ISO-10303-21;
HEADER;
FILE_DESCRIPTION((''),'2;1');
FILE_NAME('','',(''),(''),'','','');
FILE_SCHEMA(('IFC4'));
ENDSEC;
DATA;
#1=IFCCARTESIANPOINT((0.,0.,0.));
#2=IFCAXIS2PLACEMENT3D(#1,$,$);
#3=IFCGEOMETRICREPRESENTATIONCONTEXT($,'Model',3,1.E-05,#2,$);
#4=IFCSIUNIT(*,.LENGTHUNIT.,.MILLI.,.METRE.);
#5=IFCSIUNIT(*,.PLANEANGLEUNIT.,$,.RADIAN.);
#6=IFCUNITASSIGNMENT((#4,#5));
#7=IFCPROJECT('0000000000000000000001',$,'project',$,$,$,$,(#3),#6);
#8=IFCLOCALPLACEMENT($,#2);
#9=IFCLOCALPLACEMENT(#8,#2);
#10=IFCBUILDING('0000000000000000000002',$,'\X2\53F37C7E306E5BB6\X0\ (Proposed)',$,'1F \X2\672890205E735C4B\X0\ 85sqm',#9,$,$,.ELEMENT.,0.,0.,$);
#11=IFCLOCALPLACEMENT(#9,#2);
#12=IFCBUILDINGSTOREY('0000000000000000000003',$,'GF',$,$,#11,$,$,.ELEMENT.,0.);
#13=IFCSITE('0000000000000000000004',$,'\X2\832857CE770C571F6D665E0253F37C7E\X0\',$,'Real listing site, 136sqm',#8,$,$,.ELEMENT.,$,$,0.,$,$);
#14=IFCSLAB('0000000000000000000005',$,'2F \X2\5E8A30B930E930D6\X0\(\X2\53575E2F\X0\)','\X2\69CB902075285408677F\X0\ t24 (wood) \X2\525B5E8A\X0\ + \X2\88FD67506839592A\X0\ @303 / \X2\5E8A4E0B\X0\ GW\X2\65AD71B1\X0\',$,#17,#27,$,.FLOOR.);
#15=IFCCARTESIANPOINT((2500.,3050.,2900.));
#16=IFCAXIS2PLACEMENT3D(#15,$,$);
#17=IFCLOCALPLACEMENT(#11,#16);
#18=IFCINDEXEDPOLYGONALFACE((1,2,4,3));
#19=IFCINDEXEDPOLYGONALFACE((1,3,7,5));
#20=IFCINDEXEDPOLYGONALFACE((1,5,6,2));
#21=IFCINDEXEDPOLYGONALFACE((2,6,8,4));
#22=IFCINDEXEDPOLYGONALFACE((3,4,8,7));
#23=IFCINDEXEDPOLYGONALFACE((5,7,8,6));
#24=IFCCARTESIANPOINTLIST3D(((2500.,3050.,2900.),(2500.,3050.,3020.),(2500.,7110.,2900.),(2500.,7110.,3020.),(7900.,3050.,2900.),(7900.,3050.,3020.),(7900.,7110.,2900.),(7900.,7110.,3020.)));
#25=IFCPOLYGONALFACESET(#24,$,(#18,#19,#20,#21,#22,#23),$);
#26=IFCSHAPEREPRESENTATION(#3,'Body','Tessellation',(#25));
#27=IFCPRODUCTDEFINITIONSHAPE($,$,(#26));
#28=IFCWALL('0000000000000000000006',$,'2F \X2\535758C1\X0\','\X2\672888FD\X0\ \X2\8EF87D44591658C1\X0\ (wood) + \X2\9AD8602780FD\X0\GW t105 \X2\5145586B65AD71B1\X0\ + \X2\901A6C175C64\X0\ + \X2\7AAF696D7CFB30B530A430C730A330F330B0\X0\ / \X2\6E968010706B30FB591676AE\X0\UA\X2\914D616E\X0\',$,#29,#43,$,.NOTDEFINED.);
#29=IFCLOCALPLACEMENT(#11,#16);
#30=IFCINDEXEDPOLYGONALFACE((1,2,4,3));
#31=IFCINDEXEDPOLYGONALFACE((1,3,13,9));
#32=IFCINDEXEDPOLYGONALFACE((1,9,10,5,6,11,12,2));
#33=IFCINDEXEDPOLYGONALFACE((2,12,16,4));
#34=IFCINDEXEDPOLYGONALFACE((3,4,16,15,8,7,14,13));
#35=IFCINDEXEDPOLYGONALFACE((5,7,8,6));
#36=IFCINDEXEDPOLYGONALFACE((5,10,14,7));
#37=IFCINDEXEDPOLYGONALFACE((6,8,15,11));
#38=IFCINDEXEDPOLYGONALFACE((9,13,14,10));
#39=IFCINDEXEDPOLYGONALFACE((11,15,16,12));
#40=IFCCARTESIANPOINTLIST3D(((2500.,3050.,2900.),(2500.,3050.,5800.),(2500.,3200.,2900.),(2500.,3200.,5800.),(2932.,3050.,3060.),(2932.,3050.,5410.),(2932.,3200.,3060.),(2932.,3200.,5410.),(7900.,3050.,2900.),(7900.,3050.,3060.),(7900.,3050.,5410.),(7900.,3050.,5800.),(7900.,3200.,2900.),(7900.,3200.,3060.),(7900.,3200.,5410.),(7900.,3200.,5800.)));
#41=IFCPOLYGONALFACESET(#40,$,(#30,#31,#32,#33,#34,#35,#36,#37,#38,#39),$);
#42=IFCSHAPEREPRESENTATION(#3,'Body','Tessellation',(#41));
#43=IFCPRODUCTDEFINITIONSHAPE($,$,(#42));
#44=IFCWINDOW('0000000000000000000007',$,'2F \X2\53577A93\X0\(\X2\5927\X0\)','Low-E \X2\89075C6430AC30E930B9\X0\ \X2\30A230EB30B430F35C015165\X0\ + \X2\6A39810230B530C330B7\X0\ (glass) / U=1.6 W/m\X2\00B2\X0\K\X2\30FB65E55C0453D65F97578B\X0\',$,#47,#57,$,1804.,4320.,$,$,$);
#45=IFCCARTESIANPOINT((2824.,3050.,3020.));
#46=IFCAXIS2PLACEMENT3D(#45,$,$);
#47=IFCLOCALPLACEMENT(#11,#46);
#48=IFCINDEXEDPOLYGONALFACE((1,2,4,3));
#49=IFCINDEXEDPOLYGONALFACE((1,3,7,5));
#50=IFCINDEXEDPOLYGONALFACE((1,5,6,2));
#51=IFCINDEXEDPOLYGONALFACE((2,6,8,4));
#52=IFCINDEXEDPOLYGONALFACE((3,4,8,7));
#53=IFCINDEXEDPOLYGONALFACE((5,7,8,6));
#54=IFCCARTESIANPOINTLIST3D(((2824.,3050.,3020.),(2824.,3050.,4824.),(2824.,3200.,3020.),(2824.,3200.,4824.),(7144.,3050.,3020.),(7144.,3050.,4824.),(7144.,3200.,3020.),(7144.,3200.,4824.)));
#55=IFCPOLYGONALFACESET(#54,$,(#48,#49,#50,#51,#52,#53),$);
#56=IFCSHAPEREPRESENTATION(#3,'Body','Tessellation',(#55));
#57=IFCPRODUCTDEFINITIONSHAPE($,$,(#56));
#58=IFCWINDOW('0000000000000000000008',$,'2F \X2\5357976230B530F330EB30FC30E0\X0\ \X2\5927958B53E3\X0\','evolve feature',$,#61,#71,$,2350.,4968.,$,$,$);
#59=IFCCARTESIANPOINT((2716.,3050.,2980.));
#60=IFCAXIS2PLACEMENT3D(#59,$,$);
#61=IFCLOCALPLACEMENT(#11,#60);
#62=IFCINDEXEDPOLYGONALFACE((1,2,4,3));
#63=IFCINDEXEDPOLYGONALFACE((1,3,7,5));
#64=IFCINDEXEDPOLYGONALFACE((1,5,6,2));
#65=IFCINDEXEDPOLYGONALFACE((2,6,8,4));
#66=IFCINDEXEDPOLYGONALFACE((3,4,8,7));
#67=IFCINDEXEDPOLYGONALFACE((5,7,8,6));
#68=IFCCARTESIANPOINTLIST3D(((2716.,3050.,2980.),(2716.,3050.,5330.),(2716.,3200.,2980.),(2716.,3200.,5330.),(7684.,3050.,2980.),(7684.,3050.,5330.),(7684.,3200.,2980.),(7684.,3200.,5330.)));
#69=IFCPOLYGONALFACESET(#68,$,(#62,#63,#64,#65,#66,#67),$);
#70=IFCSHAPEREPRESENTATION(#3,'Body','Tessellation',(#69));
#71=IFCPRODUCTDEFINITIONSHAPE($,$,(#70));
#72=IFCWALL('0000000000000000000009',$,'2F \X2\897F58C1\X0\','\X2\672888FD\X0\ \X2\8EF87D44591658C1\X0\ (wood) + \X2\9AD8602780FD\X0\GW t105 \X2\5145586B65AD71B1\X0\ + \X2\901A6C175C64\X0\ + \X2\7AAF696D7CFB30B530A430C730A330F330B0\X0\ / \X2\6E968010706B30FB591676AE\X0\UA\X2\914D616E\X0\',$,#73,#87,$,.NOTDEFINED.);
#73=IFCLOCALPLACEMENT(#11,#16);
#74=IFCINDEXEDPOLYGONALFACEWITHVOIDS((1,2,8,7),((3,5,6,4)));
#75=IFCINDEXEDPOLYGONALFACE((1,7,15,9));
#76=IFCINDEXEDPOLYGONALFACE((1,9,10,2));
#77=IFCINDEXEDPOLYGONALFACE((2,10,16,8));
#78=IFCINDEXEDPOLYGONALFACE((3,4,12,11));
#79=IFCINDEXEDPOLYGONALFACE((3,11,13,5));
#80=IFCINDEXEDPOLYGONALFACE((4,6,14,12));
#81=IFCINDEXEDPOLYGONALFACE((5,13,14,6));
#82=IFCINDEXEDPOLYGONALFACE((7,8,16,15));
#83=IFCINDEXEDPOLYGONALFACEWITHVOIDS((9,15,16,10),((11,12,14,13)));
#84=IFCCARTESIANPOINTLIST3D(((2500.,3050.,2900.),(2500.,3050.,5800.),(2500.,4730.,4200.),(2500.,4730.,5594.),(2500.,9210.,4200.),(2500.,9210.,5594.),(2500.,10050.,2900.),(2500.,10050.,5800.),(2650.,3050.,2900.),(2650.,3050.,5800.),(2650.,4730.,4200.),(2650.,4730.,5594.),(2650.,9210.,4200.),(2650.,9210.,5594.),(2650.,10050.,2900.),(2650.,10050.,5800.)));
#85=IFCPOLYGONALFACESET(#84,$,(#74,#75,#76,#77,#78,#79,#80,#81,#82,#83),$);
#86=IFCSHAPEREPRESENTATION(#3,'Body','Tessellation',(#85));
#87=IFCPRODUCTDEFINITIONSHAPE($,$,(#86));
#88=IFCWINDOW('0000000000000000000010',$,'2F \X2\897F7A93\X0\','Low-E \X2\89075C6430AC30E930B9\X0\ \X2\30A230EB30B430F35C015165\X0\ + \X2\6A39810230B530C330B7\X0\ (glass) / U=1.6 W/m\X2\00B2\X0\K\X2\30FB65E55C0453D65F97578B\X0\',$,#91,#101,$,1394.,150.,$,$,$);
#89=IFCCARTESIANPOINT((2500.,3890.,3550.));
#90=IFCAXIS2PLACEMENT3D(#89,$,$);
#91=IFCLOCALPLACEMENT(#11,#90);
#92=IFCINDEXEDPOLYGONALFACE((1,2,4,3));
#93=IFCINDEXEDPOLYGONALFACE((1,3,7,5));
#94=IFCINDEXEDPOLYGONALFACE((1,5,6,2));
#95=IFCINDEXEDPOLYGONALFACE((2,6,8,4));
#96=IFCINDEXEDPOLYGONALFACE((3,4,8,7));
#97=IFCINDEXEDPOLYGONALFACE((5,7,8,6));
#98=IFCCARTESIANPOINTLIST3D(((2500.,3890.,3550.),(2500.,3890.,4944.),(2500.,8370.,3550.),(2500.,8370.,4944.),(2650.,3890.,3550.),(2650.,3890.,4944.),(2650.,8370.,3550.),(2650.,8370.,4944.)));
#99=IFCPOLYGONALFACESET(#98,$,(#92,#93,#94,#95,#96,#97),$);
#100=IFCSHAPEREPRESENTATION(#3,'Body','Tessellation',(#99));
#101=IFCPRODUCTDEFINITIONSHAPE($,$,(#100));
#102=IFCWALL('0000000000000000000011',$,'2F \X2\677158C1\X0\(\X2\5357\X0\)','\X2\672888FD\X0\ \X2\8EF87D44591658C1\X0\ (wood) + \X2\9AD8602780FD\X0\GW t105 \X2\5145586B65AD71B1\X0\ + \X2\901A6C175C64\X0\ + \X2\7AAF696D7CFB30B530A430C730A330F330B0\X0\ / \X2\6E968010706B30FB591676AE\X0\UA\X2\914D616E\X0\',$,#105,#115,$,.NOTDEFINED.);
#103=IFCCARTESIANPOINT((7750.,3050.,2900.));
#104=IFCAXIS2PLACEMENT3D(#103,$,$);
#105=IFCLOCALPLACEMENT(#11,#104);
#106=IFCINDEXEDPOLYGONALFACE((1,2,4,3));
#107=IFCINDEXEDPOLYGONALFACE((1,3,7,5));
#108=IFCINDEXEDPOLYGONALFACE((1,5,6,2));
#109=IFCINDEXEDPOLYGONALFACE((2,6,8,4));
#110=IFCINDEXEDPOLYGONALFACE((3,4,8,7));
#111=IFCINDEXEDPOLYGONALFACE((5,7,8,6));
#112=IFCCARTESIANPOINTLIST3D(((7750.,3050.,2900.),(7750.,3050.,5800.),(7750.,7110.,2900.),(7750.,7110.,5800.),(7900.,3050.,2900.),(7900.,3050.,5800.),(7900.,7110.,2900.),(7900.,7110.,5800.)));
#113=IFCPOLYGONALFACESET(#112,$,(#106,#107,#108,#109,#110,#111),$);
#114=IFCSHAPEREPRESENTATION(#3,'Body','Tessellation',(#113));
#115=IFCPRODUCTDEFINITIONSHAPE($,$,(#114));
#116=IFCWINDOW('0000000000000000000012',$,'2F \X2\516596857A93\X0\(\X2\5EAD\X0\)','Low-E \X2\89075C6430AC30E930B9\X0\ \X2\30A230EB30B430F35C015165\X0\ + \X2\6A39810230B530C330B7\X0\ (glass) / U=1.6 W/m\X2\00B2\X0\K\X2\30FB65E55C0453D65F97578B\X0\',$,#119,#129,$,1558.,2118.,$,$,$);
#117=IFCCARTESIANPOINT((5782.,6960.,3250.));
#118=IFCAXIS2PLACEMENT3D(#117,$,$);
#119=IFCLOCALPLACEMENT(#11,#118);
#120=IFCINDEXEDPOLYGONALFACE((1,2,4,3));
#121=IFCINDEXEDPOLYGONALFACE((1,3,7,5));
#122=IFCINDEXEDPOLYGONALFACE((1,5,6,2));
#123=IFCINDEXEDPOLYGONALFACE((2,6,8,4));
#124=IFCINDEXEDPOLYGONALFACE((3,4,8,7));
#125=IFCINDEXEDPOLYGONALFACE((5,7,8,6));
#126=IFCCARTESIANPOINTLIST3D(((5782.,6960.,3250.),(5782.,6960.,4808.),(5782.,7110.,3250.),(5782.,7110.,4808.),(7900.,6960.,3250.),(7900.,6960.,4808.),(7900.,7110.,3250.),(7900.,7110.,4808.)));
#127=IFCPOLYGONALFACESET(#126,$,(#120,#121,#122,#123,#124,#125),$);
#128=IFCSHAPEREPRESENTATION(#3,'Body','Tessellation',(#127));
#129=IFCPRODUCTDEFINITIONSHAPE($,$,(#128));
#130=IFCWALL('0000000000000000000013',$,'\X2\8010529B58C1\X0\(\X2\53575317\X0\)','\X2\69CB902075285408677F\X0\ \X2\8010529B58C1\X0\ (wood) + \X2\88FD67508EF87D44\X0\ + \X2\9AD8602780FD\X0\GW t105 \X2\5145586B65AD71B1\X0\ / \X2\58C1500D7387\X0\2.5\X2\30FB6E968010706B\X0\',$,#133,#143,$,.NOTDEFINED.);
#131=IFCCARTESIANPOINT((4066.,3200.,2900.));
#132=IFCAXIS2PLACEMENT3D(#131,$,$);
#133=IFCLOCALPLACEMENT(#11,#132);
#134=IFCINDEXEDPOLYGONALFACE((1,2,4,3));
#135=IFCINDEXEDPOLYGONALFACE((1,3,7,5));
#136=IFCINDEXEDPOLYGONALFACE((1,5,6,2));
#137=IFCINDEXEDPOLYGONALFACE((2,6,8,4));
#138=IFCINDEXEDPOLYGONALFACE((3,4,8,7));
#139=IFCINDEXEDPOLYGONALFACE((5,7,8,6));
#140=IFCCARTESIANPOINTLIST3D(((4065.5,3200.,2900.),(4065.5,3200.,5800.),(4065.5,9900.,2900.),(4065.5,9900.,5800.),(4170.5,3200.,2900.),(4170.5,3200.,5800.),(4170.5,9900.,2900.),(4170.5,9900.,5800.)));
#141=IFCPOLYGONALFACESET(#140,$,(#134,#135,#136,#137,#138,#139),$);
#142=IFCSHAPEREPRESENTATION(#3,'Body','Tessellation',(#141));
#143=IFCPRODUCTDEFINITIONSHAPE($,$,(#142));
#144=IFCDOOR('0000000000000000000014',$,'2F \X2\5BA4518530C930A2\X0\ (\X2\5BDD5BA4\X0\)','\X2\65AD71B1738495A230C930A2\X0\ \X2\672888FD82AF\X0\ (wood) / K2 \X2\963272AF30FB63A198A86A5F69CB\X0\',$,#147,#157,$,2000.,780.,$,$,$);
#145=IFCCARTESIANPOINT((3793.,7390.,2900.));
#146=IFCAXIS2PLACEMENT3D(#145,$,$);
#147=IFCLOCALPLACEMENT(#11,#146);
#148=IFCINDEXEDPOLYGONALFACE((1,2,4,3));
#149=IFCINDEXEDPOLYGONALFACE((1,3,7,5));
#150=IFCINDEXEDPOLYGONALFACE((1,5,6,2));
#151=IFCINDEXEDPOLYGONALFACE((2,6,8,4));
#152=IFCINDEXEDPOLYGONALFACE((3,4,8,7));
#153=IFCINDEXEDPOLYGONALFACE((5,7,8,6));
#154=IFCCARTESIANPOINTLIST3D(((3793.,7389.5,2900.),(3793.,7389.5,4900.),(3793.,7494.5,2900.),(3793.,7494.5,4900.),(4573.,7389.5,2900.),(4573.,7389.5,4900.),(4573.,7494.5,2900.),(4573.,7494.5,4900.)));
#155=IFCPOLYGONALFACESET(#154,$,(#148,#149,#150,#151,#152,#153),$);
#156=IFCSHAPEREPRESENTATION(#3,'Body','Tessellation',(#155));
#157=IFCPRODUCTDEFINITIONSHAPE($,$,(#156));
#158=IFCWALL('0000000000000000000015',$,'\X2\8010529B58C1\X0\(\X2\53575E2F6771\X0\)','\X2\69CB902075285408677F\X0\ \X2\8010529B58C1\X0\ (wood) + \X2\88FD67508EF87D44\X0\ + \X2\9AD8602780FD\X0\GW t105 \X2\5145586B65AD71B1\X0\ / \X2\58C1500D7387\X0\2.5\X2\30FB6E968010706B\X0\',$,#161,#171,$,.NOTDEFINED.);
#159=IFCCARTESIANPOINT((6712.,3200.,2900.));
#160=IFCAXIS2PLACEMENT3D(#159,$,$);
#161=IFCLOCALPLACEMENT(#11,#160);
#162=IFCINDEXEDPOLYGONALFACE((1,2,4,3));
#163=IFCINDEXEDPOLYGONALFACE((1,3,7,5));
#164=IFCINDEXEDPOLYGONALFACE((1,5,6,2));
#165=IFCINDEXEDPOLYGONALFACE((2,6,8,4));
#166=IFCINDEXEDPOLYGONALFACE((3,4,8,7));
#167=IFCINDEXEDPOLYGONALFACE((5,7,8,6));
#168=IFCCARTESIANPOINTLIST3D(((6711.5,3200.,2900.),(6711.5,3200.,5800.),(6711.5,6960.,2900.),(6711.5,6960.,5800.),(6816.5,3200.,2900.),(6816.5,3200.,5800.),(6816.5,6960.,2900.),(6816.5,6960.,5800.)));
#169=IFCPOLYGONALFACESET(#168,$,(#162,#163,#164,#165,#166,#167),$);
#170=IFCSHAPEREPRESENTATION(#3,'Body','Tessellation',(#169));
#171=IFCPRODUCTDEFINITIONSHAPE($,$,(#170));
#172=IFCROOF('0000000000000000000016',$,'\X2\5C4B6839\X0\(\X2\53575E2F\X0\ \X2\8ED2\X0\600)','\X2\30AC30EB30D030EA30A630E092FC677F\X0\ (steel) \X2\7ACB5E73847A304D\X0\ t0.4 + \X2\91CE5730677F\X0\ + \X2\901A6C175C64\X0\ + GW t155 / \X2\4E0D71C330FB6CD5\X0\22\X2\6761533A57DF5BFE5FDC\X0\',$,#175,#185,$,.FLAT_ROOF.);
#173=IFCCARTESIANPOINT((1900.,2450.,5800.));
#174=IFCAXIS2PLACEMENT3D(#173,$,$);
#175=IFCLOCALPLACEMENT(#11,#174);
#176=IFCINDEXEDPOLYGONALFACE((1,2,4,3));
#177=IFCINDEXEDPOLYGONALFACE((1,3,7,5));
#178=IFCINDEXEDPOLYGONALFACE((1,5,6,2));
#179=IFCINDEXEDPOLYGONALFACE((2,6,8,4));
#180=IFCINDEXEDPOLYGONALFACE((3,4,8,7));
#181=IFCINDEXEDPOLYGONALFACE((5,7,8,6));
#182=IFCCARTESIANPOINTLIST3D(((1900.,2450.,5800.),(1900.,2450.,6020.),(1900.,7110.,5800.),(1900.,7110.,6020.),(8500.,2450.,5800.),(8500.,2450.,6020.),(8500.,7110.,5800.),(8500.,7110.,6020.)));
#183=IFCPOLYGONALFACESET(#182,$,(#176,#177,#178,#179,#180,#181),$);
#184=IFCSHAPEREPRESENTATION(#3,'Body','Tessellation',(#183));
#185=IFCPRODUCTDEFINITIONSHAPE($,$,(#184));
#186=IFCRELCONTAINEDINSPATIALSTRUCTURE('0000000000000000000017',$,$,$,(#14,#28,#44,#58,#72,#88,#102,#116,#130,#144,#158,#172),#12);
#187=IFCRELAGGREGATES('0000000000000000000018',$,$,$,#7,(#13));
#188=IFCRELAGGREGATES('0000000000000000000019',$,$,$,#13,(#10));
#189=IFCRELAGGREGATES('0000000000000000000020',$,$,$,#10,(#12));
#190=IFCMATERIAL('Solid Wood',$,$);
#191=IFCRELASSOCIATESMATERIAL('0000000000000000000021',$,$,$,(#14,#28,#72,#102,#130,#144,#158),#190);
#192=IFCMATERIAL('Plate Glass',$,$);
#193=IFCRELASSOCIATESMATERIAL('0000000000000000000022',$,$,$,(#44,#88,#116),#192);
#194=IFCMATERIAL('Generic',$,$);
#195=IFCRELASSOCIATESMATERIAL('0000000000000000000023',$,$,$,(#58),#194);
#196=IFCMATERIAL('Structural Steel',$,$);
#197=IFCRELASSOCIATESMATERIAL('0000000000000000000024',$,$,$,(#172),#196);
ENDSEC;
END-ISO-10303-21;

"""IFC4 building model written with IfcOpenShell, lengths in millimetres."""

from ifc_helpers import new_model, si_unit, frame, frame_2d, origin, place, context, project, spatial, rectangle, extrude, material, element, fill, save


model = new_model("IFC4")

# Units and contexts
model_context = context("Model", 3, precision=1e-05, world=origin())
ifc_project = project(units=[si_unit("LENGTHUNIT", "METRE", prefix="MILLI"), si_unit("PLANEANGLEUNIT", "RADIAN")], contexts=[model_context])

# Site, building, storey
site_placement = place(None, origin())
site = spatial("IfcSite", under=ifc_project, at=site_placement, Name="茨城県土浦市右籾", ObjectType="Real listing site, 136sqm", CompositionType="ELEMENT", RefElevation=0.0)
building_placement = place(site_placement, origin())
building = spatial("IfcBuilding", under=site, at=building_placement, Name="右籾の家 (Proposed)", ObjectType="1F 木造平屋 85sqm", CompositionType="ELEMENT", ElevationOfRefHeight=0.0, ElevationOfTerrain=0.0)
storey_placement = place(building_placement, origin())
storey = spatial("IfcBuildingStorey", under=building, at=storey_placement, Name="GF", CompositionType="ELEMENT", Elevation=0.0)

# Slab
ifc_material_1 = material(Name="Solid Wood")
slab_placement = place(storey_placement, frame((2500.0, 3050.0, 2900.0)))
element("IfcSlab", 1, at=slab_placement, inside=storey, material=ifc_material_1, Name="2F 床スラブ(南帯)", Description="構造用合板 t24 (wood) 剛床 + 製材根太 @303 / 床下 GW断熱", PredefinedType="FLOOR", context=model_context, shape_type="SweptSolid", body=[
    extrude(rectangle(XDim=5400.0, YDim=4060.0, at=frame_2d((2700.0, 2030.0))), frame((2500.0, 3050.0, 2900.0)), (0.0, 0.0, 1.0), 120.0),
])

# Wall, openings, windows
wall_1_placement = place(storey_placement, frame((2500.0, 3050.0, 2900.0)))
wall_1 = element("IfcWall", 2, at=wall_1_placement, inside=storey, material=ifc_material_1, Name="2F 南壁", Description="木製 軸組外壁 (wood) + 高性能GW t105 充填断熱 + 通気層 + 窯業系サイディング / 準耐火・外皮UA配慮", PredefinedType="NOTDEFINED", context=model_context, shape_type="SweptSolid", body=[
    extrude(rectangle(XDim=5400.0, YDim=150.0, at=frame_2d((2700.0, 75.0))), frame((2500.0, 3050.0, 2900.0)), (0.0, 0.0, 1.0), 2900.0),
])
opening_1_placement = place(storey_placement, frame((2824.0, 3050.0, 3020.0)))
opening_1 = element("IfcOpeningElement", 3, at=opening_1_placement, cuts=wall_1, PredefinedType="NOTDEFINED", context=model_context, shape_type="SweptSolid", body=[
    extrude(rectangle(XDim=4320.0, YDim=150.0, at=frame_2d((2160.0, 75.0))), frame((2824.0, 3050.0, 3020.0)), (0.0, 0.0, 1.0), 1804.0),
])
opening_2_placement = place(storey_placement, frame((2716.0, 3050.0, 2980.0)))
opening_2 = element("IfcOpeningElement", 4, at=opening_2_placement, cuts=wall_1, PredefinedType="NOTDEFINED", context=model_context, shape_type="SweptSolid", body=[
    extrude(rectangle(XDim=4968.0, YDim=150.0, at=frame_2d((2484.0, 75.0))), frame((2716.0, 3050.0, 2980.0)), (0.0, 0.0, 1.0), 2350.0),
])
ifc_material_2 = material(Name="Plate Glass")
window_1_placement = place(storey_placement, frame((2824.0, 3050.0, 3020.0)))
window_1 = element("IfcWindow", 5, at=window_1_placement, inside=storey, material=ifc_material_2, Name="2F 南窓(大)", Description="Low-E 複層ガラス アルゴン封入 + 樹脂サッシ (glass) / U=1.6 W/m²K・日射取得型", OverallHeight=1804.0, OverallWidth=4320.0, context=model_context, shape_type="SweptSolid", body=[
    extrude(rectangle(XDim=4320.0, YDim=150.0, at=frame_2d((2160.0, 75.0))), frame((2824.0, 3050.0, 3020.0)), (0.0, 0.0, 1.0), 1804.0),
])
fill(opening_1, window_1)
ifc_material_3 = material(Name="Generic")
window_2_placement = place(storey_placement, frame((2716.0, 3050.0, 2980.0)))
window_2 = element("IfcWindow", 6, at=window_2_placement, inside=storey, material=ifc_material_3, Name="2F 南面サンルーム 大開口", Description="evolve feature", OverallHeight=2350.0, OverallWidth=4968.0, context=model_context, shape_type="SweptSolid", body=[
    extrude(rectangle(XDim=4968.0, YDim=150.0, at=frame_2d((2484.0, 75.0))), frame((2716.0, 3050.0, 2980.0)), (0.0, 0.0, 1.0), 2350.0),
])
fill(opening_2, window_2)

# Walls, openings, windows
wall_2_placement = place(storey_placement, frame((2500.0, 3050.0, 2900.0)))
wall_2 = element("IfcWall", 7, at=wall_2_placement, inside=storey, material=ifc_material_1, Name="2F 西壁", Description="木製 軸組外壁 (wood) + 高性能GW t105 充填断熱 + 通気層 + 窯業系サイディング / 準耐火・外皮UA配慮", PredefinedType="NOTDEFINED", context=model_context, shape_type="SweptSolid", body=[
    extrude(rectangle(XDim=150.0, YDim=7000.0, at=frame_2d((75.0, 3500.0))), frame((2500.0, 3050.0, 2900.0)), (0.0, 0.0, 1.0), 2900.0),
])
opening_3_placement = place(storey_placement, frame((2500.0, 3890.0, 3550.0)))
opening_3 = element("IfcOpeningElement", 8, at=opening_3_placement, cuts=wall_2, PredefinedType="NOTDEFINED", context=model_context, shape_type="SweptSolid", body=[
    extrude(rectangle(XDim=150.0, YDim=4480.0, at=frame_2d((75.0, 2240.0))), frame((2500.0, 3890.0, 3550.0)), (0.0, 0.0, 1.0), 1394.0),
])
window_3_placement = place(storey_placement, frame((2500.0, 3890.0, 3550.0)))
window_3 = element("IfcWindow", 9, at=window_3_placement, inside=storey, material=ifc_material_2, Name="2F 西窓", Description="Low-E 複層ガラス アルゴン封入 + 樹脂サッシ (glass) / U=1.6 W/m²K・日射取得型", OverallHeight=1394.0, OverallWidth=150.0, context=model_context, shape_type="SweptSolid", body=[
    extrude(rectangle(XDim=150.0, YDim=4480.0, at=frame_2d((75.0, 2240.0))), frame((2500.0, 3890.0, 3550.0)), (0.0, 0.0, 1.0), 1394.0),
])
fill(opening_3, window_3)
wall_3_placement = place(storey_placement, frame((7750.0, 3050.0, 2900.0)))
wall_3 = element("IfcWall", 10, at=wall_3_placement, inside=storey, material=ifc_material_1, Name="2F 東壁(南)", Description="木製 軸組外壁 (wood) + 高性能GW t105 充填断熱 + 通気層 + 窯業系サイディング / 準耐火・外皮UA配慮", PredefinedType="NOTDEFINED", context=model_context, shape_type="SweptSolid", body=[
    extrude(rectangle(XDim=150.0, YDim=4060.0, at=frame_2d((75.0, 2030.0))), frame((7750.0, 3050.0, 2900.0)), (0.0, 0.0, 1.0), 2900.0),
])
opening_4_placement = place(storey_placement, frame((5782.0, 6960.0, 3250.0)))
opening_4 = element("IfcOpeningElement", 11, at=opening_4_placement, cuts=wall_3, PredefinedType="NOTDEFINED", context=model_context, shape_type="SweptSolid", body=[
    extrude(rectangle(XDim=2118.0, YDim=150.0, at=frame_2d((1059.0, 75.0))), frame((5782.0, 6960.0, 3250.0)), (0.0, 0.0, 1.0), 1558.0),
])
window_4_placement = place(storey_placement, frame((5782.0, 6960.0, 3250.0)))
window_4 = element("IfcWindow", 12, at=window_4_placement, inside=storey, material=ifc_material_2, Name="2F 入隅窓(庭)", Description="Low-E 複層ガラス アルゴン封入 + 樹脂サッシ (glass) / U=1.6 W/m²K・日射取得型", OverallHeight=1558.0, OverallWidth=2118.0, context=model_context, shape_type="SweptSolid", body=[
    extrude(rectangle(XDim=2118.0, YDim=150.0, at=frame_2d((1059.0, 75.0))), frame((5782.0, 6960.0, 3250.0)), (0.0, 0.0, 1.0), 1558.0),
])
fill(opening_4, window_4)

# Wall, opening, door
wall_4_placement = place(storey_placement, frame((4066.0, 3200.0, 2900.0)))
wall_4 = element("IfcWall", 13, at=wall_4_placement, inside=storey, material=ifc_material_1, Name="耐力壁(南北)", Description="構造用合板 耐力壁 (wood) + 製材軸組 + 高性能GW t105 充填断熱 / 壁倍率2.5・準耐火", PredefinedType="NOTDEFINED", context=model_context, shape_type="SweptSolid", body=[
    extrude(rectangle(XDim=105.0, YDim=6700.0, at=frame_2d((52.0, 3350.0))), frame((4066.0, 3200.0, 2900.0)), (0.0, 0.0, 1.0), 2900.0),
])
opening_5_placement = place(storey_placement, frame((3793.0, 7390.0, 2900.0)))
opening_5 = element("IfcOpeningElement", 14, at=opening_5_placement, cuts=wall_4, PredefinedType="NOTDEFINED", context=model_context, shape_type="SweptSolid", body=[
    extrude(rectangle(XDim=780.0, YDim=105.0, at=frame_2d((390.0, 52.0))), frame((3793.0, 7390.0, 2900.0)), (0.0, 0.0, 1.0), 2000.0),
])
door_placement = place(storey_placement, frame((3793.0, 7390.0, 2900.0)))
door = element("IfcDoor", 15, at=door_placement, inside=storey, material=ifc_material_1, Name="2F 室内ドア (寝室)", Description="断熱玄関ドア 木製芯 (wood) / K2 防犯・採風機構", OverallHeight=2000.0, OverallWidth=780.0, context=model_context, shape_type="SweptSolid", body=[
    extrude(rectangle(XDim=780.0, YDim=105.0, at=frame_2d((390.0, 52.0))), frame((3793.0, 7390.0, 2900.0)), (0.0, 0.0, 1.0), 2000.0),
])
fill(opening_5, door)

# Wall
wall_5_placement = place(storey_placement, frame((6712.0, 3200.0, 2900.0)))
element("IfcWall", 16, at=wall_5_placement, inside=storey, material=ifc_material_1, Name="耐力壁(南帯東)", Description="構造用合板 耐力壁 (wood) + 製材軸組 + 高性能GW t105 充填断熱 / 壁倍率2.5・準耐火", PredefinedType="NOTDEFINED", context=model_context, shape_type="SweptSolid", body=[
    extrude(rectangle(XDim=105.0, YDim=3760.0, at=frame_2d((52.0, 1880.0))), frame((6712.0, 3200.0, 2900.0)), (0.0, 0.0, 1.0), 2900.0),
])

# Roof
ifc_material_4 = material(Name="Structural Steel")
for number, where, name in (
    (17, (1900.0, 2450.0, 5800.0), "屋根(南帯 軒600)"),
):
    element("IfcRoof", number, at=place(storey_placement, frame(where)), inside=storey, material=ifc_material_4, Name=name, Description="ガルバリウム鋼板 (steel) 立平葺き t0.4 + 野地板 + 通気層 + GW t155 / 不燃・法22条区域対応", PredefinedType="FLAT_ROOF", context=model_context, shape_type="SweptSolid", body=[
        extrude(rectangle(XDim=6600.0, YDim=4660.0, at=frame_2d((3300.0, 2330.0))), frame((1900.0, 2450.0, 5800.0)), (0.0, 0.0, 1.0), 220.0),
    ])

save(model, "model.ifc")
